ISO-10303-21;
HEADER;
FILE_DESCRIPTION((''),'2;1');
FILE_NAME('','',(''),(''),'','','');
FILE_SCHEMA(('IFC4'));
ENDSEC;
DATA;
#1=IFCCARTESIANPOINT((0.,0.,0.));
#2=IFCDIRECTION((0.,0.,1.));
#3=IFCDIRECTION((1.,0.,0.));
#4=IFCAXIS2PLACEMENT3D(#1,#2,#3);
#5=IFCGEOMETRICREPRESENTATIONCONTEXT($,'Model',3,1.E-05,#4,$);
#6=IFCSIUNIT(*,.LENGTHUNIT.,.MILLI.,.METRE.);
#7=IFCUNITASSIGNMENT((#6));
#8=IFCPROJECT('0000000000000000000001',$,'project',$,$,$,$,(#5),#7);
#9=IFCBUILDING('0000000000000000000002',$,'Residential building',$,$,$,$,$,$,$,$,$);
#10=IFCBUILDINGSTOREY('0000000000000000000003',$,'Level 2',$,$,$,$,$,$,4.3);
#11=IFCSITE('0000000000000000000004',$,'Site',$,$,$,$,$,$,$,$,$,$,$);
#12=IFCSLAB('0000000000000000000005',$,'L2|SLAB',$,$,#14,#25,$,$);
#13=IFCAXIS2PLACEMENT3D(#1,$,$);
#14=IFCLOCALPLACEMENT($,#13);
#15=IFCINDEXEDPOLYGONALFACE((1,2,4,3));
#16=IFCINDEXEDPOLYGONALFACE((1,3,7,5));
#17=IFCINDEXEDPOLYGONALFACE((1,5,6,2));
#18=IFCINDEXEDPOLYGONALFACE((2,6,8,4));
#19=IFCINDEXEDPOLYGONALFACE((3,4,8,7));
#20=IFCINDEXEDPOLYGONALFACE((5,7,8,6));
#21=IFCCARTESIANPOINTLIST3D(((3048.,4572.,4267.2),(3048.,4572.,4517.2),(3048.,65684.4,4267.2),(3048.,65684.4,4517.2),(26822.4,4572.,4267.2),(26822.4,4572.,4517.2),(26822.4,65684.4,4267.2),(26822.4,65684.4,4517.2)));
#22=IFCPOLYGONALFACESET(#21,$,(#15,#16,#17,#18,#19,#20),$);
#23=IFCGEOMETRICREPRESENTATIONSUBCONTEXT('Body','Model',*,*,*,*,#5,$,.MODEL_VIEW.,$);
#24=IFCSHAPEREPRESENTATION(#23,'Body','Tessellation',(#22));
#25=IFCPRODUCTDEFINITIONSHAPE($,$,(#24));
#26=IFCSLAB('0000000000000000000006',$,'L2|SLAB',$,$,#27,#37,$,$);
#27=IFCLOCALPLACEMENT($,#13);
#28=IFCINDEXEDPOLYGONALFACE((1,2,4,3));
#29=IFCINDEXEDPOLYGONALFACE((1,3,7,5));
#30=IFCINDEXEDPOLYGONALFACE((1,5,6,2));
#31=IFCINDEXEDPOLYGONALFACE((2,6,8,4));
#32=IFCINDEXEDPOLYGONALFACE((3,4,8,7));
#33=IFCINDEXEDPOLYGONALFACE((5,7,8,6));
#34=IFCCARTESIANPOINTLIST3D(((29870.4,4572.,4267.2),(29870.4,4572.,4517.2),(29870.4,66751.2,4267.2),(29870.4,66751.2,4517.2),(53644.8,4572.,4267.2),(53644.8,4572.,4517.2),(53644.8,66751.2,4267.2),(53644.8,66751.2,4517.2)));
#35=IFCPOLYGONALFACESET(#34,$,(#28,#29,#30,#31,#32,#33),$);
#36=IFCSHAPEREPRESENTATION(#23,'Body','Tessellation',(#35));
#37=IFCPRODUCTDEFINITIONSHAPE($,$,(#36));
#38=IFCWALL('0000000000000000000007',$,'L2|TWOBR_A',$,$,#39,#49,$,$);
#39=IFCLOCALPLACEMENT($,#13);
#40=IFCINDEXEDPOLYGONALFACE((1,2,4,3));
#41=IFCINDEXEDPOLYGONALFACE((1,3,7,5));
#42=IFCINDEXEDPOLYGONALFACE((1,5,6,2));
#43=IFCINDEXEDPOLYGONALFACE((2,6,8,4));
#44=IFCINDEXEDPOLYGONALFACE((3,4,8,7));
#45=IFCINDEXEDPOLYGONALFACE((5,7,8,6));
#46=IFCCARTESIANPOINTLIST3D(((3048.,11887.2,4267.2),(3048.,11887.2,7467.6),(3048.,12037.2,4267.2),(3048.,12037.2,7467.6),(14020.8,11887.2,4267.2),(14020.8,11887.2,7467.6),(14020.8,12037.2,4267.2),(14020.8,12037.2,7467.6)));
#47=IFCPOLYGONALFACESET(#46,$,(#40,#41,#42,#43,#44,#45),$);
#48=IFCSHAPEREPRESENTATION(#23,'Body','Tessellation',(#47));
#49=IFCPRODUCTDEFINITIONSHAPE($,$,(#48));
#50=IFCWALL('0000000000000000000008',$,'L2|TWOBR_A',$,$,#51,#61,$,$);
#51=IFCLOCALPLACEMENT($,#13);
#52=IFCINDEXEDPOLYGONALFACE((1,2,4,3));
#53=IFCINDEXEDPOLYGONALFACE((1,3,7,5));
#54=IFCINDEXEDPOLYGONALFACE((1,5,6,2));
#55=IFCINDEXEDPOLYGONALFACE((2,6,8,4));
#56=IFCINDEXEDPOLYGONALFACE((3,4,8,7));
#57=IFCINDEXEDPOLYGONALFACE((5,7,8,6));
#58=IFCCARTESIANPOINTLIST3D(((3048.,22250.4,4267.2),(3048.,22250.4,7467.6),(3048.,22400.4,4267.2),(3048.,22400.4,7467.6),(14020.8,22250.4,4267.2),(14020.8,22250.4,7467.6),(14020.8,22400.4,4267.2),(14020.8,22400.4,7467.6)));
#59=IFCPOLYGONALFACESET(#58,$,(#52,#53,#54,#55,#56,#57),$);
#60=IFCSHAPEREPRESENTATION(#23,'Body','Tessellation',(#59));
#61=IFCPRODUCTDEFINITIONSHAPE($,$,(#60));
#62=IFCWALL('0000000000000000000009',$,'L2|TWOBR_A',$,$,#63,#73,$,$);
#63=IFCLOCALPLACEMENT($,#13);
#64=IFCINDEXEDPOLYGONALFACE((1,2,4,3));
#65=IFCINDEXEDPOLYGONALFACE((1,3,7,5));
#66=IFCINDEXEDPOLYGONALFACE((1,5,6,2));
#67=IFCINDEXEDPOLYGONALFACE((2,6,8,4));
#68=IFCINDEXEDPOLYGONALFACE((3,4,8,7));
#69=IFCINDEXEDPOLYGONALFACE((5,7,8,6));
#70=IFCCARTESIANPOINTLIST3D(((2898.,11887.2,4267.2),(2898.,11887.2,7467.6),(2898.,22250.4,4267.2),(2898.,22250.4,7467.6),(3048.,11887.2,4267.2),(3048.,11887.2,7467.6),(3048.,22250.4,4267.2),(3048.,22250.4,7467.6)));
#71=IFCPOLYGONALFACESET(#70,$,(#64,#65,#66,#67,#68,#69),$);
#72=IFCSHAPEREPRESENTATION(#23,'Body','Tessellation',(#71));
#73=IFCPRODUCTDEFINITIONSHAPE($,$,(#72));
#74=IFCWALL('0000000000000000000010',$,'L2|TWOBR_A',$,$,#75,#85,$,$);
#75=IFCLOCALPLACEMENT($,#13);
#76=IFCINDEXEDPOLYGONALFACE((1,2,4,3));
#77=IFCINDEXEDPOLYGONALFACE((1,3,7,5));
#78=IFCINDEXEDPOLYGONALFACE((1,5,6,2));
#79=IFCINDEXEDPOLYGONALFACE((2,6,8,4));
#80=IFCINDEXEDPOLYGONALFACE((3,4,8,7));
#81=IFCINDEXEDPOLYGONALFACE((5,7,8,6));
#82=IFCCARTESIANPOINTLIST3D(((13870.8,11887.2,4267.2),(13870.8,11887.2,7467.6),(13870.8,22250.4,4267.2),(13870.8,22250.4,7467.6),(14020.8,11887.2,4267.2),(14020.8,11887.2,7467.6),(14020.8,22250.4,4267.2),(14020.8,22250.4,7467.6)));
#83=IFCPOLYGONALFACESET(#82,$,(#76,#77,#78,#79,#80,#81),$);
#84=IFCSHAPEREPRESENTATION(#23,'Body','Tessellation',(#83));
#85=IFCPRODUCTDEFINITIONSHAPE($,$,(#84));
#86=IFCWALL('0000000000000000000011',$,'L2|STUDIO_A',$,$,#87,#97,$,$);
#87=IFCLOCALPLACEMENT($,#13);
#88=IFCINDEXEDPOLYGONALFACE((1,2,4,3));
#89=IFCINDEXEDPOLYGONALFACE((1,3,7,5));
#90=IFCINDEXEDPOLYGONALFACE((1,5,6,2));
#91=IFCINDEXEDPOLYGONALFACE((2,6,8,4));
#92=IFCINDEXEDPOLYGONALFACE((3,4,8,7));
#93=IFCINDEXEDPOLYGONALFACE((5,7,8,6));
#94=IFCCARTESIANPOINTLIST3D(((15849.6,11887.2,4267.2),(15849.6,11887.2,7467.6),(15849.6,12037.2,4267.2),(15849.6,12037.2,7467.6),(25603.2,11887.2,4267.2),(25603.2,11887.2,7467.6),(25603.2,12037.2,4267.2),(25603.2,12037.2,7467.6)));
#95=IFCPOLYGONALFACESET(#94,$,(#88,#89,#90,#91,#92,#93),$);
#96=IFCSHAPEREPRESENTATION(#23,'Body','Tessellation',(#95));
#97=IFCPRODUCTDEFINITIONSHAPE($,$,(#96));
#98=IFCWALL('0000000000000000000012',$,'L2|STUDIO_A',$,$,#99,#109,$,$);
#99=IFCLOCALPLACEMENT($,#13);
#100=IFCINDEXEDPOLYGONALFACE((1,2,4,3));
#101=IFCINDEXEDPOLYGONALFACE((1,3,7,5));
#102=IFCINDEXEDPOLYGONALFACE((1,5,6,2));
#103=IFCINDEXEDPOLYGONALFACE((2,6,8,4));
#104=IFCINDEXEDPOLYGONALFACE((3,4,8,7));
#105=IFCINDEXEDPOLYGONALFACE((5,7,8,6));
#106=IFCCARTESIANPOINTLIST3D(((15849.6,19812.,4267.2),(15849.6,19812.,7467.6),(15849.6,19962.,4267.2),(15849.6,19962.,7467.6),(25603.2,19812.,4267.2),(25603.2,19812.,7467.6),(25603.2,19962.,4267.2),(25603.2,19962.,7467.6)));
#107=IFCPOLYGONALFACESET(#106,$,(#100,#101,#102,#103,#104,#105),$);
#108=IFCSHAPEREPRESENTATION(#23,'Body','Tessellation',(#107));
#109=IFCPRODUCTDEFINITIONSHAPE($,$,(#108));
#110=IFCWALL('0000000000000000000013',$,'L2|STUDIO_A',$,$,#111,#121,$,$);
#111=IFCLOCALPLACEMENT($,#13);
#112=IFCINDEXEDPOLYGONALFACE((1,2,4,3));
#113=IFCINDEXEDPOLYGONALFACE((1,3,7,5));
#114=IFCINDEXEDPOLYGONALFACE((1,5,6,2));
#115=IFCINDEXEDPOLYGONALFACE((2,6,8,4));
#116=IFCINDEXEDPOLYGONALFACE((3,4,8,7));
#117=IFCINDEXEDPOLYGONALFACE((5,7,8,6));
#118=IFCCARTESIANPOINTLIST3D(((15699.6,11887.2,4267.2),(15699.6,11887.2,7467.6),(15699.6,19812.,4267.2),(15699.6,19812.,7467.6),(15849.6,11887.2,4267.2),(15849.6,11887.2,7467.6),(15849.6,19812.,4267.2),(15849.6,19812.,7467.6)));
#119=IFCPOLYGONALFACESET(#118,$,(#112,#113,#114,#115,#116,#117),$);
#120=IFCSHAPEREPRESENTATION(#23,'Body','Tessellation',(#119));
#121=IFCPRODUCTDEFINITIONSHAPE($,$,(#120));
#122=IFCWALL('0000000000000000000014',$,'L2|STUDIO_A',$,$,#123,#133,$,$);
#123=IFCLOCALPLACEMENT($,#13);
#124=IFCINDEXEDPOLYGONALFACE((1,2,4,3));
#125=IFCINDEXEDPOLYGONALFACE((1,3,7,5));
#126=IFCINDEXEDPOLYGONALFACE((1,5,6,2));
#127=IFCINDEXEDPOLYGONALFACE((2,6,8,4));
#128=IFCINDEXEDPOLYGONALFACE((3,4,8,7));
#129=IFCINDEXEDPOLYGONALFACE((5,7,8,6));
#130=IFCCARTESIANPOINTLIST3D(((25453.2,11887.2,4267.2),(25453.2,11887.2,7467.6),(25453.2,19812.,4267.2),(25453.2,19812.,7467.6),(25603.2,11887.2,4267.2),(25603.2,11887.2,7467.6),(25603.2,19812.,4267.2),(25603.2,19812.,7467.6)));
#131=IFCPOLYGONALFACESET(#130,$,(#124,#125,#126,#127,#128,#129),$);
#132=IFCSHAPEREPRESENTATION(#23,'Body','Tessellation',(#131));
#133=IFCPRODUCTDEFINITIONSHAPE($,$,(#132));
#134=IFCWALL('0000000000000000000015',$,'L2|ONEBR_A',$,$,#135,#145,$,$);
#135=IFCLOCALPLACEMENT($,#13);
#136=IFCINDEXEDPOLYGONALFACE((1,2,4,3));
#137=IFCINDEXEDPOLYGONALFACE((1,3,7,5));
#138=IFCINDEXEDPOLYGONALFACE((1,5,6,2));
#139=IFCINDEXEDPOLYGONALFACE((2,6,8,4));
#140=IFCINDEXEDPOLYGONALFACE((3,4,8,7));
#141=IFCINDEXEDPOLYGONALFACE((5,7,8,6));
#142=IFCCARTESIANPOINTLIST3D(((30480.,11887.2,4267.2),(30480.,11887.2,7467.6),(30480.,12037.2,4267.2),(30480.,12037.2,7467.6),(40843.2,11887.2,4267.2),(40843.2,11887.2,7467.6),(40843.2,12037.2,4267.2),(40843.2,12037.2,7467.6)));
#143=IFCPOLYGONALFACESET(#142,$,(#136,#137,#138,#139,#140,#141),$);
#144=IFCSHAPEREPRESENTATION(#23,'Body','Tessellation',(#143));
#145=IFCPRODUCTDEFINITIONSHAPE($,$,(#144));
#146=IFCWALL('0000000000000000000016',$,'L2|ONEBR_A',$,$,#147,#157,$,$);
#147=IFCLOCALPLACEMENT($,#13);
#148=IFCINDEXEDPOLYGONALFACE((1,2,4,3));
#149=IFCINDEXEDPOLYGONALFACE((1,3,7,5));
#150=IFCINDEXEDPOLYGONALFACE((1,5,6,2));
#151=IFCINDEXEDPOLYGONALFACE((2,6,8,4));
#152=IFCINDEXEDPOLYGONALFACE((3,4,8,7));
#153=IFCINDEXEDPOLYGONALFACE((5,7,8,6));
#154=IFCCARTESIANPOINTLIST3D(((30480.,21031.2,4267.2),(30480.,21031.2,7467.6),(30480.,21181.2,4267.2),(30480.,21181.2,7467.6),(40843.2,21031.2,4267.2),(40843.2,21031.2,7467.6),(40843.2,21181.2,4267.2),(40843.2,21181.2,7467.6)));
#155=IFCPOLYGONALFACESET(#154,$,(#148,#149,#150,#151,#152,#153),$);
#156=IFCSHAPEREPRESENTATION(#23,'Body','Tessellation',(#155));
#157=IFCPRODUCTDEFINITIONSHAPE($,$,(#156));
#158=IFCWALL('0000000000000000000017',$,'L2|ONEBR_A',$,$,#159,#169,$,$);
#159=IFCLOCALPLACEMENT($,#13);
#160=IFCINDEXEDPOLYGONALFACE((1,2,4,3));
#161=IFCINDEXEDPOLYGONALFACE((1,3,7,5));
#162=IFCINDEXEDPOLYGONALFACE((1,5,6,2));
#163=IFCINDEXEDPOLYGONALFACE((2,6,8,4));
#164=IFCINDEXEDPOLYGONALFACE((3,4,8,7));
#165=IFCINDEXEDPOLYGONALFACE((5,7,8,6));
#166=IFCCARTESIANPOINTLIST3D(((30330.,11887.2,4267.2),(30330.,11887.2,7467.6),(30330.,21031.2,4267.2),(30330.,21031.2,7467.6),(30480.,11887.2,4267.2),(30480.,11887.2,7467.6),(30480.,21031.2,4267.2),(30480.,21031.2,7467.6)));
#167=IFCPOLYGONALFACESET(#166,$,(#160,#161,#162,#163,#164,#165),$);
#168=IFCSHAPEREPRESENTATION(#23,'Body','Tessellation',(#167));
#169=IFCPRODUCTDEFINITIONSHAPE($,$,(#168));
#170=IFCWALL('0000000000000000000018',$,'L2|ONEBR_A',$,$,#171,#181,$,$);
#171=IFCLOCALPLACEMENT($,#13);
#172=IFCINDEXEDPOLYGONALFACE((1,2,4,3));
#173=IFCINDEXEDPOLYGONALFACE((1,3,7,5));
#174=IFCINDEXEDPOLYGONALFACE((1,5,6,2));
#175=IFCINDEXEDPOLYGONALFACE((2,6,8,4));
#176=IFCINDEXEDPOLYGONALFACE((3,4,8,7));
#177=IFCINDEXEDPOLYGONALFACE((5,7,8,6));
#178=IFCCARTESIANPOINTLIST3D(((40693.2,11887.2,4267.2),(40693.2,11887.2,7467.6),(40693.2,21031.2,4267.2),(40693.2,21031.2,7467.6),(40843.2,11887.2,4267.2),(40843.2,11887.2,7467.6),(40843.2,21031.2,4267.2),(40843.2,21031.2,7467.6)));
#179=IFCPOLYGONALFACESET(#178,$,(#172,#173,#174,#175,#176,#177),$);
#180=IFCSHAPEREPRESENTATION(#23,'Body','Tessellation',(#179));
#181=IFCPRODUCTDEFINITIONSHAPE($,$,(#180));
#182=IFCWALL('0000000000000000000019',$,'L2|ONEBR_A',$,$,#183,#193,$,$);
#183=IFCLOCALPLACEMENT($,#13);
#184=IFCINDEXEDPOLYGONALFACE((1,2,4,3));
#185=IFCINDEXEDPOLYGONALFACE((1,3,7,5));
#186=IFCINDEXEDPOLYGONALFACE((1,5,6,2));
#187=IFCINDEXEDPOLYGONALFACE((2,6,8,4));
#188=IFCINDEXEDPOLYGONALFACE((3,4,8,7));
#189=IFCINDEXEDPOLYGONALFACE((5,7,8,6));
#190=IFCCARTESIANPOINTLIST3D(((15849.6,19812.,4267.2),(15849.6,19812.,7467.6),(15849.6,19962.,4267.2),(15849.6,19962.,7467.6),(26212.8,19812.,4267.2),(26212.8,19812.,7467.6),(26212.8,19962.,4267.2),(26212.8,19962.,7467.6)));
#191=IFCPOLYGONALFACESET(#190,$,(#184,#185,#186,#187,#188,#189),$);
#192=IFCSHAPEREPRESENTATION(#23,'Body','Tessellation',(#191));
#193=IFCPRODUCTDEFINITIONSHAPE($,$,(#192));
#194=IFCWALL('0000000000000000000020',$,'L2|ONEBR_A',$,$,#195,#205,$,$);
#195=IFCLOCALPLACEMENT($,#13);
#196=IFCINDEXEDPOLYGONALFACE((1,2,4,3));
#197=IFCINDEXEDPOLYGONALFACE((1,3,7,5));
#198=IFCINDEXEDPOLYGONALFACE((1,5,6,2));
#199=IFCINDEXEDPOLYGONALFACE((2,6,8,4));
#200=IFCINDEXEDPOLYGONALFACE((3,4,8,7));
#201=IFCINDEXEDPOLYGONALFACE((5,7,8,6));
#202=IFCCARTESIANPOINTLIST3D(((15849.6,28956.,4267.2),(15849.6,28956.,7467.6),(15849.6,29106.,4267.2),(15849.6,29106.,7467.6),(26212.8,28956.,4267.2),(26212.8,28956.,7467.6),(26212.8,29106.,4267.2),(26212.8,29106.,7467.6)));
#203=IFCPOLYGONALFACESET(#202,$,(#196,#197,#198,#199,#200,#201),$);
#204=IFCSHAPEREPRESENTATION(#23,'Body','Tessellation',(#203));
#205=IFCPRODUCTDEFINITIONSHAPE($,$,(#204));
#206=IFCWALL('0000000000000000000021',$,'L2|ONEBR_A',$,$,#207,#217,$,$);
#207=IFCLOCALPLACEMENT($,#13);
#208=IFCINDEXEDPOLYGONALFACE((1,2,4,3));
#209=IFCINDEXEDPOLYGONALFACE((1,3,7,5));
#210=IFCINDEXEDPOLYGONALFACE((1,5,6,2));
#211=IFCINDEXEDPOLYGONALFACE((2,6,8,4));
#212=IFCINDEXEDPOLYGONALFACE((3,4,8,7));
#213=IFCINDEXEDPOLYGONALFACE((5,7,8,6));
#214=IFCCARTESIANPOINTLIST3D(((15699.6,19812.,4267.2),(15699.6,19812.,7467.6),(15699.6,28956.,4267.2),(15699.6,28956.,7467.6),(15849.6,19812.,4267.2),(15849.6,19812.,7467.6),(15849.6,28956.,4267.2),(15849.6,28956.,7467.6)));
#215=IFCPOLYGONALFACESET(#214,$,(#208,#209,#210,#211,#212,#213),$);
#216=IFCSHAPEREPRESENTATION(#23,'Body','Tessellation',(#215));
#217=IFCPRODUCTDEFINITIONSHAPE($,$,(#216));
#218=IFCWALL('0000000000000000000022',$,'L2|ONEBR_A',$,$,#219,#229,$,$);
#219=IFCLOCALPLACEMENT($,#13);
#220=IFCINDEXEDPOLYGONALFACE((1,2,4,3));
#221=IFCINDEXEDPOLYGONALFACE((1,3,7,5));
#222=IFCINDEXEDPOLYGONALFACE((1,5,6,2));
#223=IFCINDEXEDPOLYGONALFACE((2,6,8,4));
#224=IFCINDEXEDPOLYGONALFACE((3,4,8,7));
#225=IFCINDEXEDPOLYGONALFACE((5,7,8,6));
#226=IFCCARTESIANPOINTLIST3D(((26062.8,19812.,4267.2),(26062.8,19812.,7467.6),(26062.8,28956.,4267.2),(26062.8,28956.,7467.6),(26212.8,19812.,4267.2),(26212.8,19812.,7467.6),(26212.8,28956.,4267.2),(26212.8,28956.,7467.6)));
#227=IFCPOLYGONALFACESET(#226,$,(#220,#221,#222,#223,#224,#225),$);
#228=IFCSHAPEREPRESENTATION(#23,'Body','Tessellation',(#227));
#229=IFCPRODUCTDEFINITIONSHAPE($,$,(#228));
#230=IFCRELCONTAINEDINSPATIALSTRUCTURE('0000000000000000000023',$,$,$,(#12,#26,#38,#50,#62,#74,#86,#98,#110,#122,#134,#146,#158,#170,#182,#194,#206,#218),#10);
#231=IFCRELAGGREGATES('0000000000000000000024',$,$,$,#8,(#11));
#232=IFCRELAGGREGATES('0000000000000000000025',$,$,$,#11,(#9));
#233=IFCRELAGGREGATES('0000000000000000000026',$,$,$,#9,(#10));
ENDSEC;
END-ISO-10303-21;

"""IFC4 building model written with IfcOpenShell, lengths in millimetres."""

from ifc_helpers import new_model, si_unit, frame, origin_with_axes, place, context, subcontext, project, spatial, indexed_curve, outline, extrude, element, save


model = new_model("IFC4")

# Units and contexts
model_context = context("Model", 3, precision=1e-05, world=origin_with_axes())
body_context = subcontext(model_context, "Body", "Model", "MODEL_VIEW")
ifc_project = project(units=[si_unit("LENGTHUNIT", "METRE", prefix="MILLI")], contexts=[model_context])

# Site, building, storey
site = spatial("IfcSite", under=ifc_project, Name="Site")
building = spatial("IfcBuilding", under=site, Name="Residential building")
storey = spatial("IfcBuildingStorey", under=building, Name="Level 2", Elevation=4.3)

# Slabs
slab_1_placement = place(None, frame((3048.0, 4572.0, 4267.2), z_axis=(0.0, 0.0, 1.0), x_axis=(1.0, 0.0, 0.0)))
element("IfcSlab", 1, at=slab_1_placement, inside=storey, Name="L2|SLAB", context=body_context, shape_type="SweptSolid", body=[
    extrude(outline(indexed_curve([(0.0, 0.0), (23774.4, 0.0), (23774.4, 61112.4), (0.0, 61112.4), (0.0, 0.0)])), None, (0.0, 0.0, 1.0), 250.0),
])
slab_2_placement = place(None, frame((29870.4, 4572.0, 4267.2), z_axis=(0.0, 0.0, 1.0), x_axis=(1.0, 0.0, 0.0)))
element("IfcSlab", 2, at=slab_2_placement, inside=storey, Name="L2|SLAB", context=body_context, shape_type="SweptSolid", body=[
    extrude(outline(indexed_curve([(0.0, 0.0), (23774.4, 0.0), (23774.4, 62179.2), (0.0, 62179.2), (0.0, 0.0)])), None, (0.0, 0.0, 1.0), 250.0),
])

# Walls
for number, where, z_axis, x_axis, name in (
    (3, (3048.0, 11887.2, 4267.2), (0.0, 0.0, 1.0), (1.0, 0.0, 0.0), "L2|TWOBR_A"),
    (4, (3048.0, 22250.4, 4267.2), (0.0, 0.0, 1.0), (1.0, 0.0, 0.0), "L2|TWOBR_A"),
):
    element("IfcWall", number, at=place(None, frame(where, z_axis=z_axis, x_axis=x_axis)), inside=storey, Name=name, context=body_context, shape_type="SweptSolid", body=[
        extrude(outline(indexed_curve([(0.0, 0.0), (0.0, 150.0), (10972.8, 150.0), (10972.8, 0.0), (0.0, 0.0)], self_intersect=False)), origin_with_axes(), (0.0, 0.0, 1.0), 3200.4),
    ])
for number, where, z_axis, x_axis, name in (
    (5, (3048.0, 11887.2, 4267.2), (0.0, 0.0, 1.0), (0.0, 1.0, 0.0), "L2|TWOBR_A"),
    (6, (14020.8, 11887.2, 4267.2), (0.0, 0.0, 1.0), (0.0, 1.0, 0.0), "L2|TWOBR_A"),
):
    element("IfcWall", number, at=place(None, frame(where, z_axis=z_axis, x_axis=x_axis)), inside=storey, Name=name, context=body_context, shape_type="SweptSolid", body=[
        extrude(outline(indexed_curve([(0.0, 0.0), (0.0, 150.0), (10363.2, 150.0), (10363.2, 0.0), (0.0, 0.0)], self_intersect=False)), origin_with_axes(), (0.0, 0.0, 1.0), 3200.4),
    ])
for number, where, z_axis, x_axis, name in (
    (7, (15849.6, 11887.2, 4267.2), (0.0, 0.0, 1.0), (1.0, 0.0, 0.0), "L2|STUDIO_A"),
    (8, (15849.6, 19812.0, 4267.2), (0.0, 0.0, 1.0), (1.0, 0.0, 0.0), "L2|STUDIO_A"),
):
    element("IfcWall", number, at=place(None, frame(where, z_axis=z_axis, x_axis=x_axis)), inside=storey, Name=name, context=body_context, shape_type="SweptSolid", body=[
        extrude(outline(indexed_curve([(0.0, 0.0), (0.0, 150.0), (9753.6, 150.0), (9753.6, 0.0), (0.0, 0.0)], self_intersect=False)), origin_with_axes(), (0.0, 0.0, 1.0), 3200.4),
    ])
for number, where, z_axis, x_axis, name in (
    (9, (15849.6, 11887.2, 4267.2), (0.0, 0.0, 1.0), (0.0, 1.0, 0.0), "L2|STUDIO_A"),
    (10, (25603.2, 11887.2, 4267.2), (0.0, 0.0, 1.0), (0.0, 1.0, 0.0), "L2|STUDIO_A"),
):
    element("IfcWall", number, at=place(None, frame(where, z_axis=z_axis, x_axis=x_axis)), inside=storey, Name=name, context=body_context, shape_type="SweptSolid", body=[
        extrude(outline(indexed_curve([(0.0, 0.0), (0.0, 150.0), (7924.8, 150.0), (7924.8, 0.0), (0.0, 0.0)], self_intersect=False)), origin_with_axes(), (0.0, 0.0, 1.0), 3200.4),
    ])
for number, where, z_axis, x_axis, name in (
    (11, (30480.0, 11887.2, 4267.2), (0.0, 0.0, 1.0), (1.0, 0.0, 0.0), "L2|ONEBR_A"),
    (12, (30480.0, 21031.2, 4267.2), (0.0, 0.0, 1.0), (1.0, 0.0, 0.0), "L2|ONEBR_A"),
):
    element("IfcWall", number, at=place(None, frame(where, z_axis=z_axis, x_axis=x_axis)), inside=storey, Name=name, context=body_context, shape_type="SweptSolid", body=[
        extrude(outline(indexed_curve([(0.0, 0.0), (0.0, 150.0), (10363.2, 150.0), (10363.2, 0.0), (0.0, 0.0)], self_intersect=False)), origin_with_axes(), (0.0, 0.0, 1.0), 3200.4),
    ])
for number, where, z_axis, x_axis, name in (
    (13, (30480.0, 11887.2, 4267.2), (0.0, 0.0, 1.0), (0.0, 1.0, 0.0), "L2|ONEBR_A"),
    (14, (40843.2, 11887.2, 4267.2), (0.0, 0.0, 1.0), (0.0, 1.0, 0.0), "L2|ONEBR_A"),
):
    element("IfcWall", number, at=place(None, frame(where, z_axis=z_axis, x_axis=x_axis)), inside=storey, Name=name, context=body_context, shape_type="SweptSolid", body=[
        extrude(outline(indexed_curve([(0.0, 0.0), (0.0, 150.0), (9144.0, 150.0), (9144.0, 0.0), (0.0, 0.0)], self_intersect=False)), origin_with_axes(), (0.0, 0.0, 1.0), 3200.4),
    ])
for number, where, z_axis, x_axis, name in (
    (15, (15849.6, 19812.0, 4267.2), (0.0, 0.0, 1.0), (1.0, 0.0, 0.0), "L2|ONEBR_A"),
    (16, (15849.6, 28956.0, 4267.2), (0.0, 0.0, 1.0), (1.0, 0.0, 0.0), "L2|ONEBR_A"),
):
    element("IfcWall", number, at=place(None, frame(where, z_axis=z_axis, x_axis=x_axis)), inside=storey, Name=name, context=body_context, shape_type="SweptSolid", body=[
        extrude(outline(indexed_curve([(0.0, 0.0), (0.0, 150.0), (10363.2, 150.0), (10363.2, 0.0), (0.0, 0.0)], self_intersect=False)), origin_with_axes(), (0.0, 0.0, 1.0), 3200.4),
    ])
for number, where, z_axis, x_axis, name in (
    (17, (15849.6, 19812.0, 4267.2), (0.0, 0.0, 1.0), (0.0, 1.0, 0.0), "L2|ONEBR_A"),
    (18, (26212.8, 19812.0, 4267.2), (0.0, 0.0, 1.0), (0.0, 1.0, 0.0), "L2|ONEBR_A"),
):
    element("IfcWall", number, at=place(None, frame(where, z_axis=z_axis, x_axis=x_axis)), inside=storey, Name=name, context=body_context, shape_type="SweptSolid", body=[
        extrude(outline(indexed_curve([(0.0, 0.0), (0.0, 150.0), (9144.0, 150.0), (9144.0, 0.0), (0.0, 0.0)], self_intersect=False)), origin_with_axes(), (0.0, 0.0, 1.0), 3200.4),
    ])

save(model, "model.ifc")
